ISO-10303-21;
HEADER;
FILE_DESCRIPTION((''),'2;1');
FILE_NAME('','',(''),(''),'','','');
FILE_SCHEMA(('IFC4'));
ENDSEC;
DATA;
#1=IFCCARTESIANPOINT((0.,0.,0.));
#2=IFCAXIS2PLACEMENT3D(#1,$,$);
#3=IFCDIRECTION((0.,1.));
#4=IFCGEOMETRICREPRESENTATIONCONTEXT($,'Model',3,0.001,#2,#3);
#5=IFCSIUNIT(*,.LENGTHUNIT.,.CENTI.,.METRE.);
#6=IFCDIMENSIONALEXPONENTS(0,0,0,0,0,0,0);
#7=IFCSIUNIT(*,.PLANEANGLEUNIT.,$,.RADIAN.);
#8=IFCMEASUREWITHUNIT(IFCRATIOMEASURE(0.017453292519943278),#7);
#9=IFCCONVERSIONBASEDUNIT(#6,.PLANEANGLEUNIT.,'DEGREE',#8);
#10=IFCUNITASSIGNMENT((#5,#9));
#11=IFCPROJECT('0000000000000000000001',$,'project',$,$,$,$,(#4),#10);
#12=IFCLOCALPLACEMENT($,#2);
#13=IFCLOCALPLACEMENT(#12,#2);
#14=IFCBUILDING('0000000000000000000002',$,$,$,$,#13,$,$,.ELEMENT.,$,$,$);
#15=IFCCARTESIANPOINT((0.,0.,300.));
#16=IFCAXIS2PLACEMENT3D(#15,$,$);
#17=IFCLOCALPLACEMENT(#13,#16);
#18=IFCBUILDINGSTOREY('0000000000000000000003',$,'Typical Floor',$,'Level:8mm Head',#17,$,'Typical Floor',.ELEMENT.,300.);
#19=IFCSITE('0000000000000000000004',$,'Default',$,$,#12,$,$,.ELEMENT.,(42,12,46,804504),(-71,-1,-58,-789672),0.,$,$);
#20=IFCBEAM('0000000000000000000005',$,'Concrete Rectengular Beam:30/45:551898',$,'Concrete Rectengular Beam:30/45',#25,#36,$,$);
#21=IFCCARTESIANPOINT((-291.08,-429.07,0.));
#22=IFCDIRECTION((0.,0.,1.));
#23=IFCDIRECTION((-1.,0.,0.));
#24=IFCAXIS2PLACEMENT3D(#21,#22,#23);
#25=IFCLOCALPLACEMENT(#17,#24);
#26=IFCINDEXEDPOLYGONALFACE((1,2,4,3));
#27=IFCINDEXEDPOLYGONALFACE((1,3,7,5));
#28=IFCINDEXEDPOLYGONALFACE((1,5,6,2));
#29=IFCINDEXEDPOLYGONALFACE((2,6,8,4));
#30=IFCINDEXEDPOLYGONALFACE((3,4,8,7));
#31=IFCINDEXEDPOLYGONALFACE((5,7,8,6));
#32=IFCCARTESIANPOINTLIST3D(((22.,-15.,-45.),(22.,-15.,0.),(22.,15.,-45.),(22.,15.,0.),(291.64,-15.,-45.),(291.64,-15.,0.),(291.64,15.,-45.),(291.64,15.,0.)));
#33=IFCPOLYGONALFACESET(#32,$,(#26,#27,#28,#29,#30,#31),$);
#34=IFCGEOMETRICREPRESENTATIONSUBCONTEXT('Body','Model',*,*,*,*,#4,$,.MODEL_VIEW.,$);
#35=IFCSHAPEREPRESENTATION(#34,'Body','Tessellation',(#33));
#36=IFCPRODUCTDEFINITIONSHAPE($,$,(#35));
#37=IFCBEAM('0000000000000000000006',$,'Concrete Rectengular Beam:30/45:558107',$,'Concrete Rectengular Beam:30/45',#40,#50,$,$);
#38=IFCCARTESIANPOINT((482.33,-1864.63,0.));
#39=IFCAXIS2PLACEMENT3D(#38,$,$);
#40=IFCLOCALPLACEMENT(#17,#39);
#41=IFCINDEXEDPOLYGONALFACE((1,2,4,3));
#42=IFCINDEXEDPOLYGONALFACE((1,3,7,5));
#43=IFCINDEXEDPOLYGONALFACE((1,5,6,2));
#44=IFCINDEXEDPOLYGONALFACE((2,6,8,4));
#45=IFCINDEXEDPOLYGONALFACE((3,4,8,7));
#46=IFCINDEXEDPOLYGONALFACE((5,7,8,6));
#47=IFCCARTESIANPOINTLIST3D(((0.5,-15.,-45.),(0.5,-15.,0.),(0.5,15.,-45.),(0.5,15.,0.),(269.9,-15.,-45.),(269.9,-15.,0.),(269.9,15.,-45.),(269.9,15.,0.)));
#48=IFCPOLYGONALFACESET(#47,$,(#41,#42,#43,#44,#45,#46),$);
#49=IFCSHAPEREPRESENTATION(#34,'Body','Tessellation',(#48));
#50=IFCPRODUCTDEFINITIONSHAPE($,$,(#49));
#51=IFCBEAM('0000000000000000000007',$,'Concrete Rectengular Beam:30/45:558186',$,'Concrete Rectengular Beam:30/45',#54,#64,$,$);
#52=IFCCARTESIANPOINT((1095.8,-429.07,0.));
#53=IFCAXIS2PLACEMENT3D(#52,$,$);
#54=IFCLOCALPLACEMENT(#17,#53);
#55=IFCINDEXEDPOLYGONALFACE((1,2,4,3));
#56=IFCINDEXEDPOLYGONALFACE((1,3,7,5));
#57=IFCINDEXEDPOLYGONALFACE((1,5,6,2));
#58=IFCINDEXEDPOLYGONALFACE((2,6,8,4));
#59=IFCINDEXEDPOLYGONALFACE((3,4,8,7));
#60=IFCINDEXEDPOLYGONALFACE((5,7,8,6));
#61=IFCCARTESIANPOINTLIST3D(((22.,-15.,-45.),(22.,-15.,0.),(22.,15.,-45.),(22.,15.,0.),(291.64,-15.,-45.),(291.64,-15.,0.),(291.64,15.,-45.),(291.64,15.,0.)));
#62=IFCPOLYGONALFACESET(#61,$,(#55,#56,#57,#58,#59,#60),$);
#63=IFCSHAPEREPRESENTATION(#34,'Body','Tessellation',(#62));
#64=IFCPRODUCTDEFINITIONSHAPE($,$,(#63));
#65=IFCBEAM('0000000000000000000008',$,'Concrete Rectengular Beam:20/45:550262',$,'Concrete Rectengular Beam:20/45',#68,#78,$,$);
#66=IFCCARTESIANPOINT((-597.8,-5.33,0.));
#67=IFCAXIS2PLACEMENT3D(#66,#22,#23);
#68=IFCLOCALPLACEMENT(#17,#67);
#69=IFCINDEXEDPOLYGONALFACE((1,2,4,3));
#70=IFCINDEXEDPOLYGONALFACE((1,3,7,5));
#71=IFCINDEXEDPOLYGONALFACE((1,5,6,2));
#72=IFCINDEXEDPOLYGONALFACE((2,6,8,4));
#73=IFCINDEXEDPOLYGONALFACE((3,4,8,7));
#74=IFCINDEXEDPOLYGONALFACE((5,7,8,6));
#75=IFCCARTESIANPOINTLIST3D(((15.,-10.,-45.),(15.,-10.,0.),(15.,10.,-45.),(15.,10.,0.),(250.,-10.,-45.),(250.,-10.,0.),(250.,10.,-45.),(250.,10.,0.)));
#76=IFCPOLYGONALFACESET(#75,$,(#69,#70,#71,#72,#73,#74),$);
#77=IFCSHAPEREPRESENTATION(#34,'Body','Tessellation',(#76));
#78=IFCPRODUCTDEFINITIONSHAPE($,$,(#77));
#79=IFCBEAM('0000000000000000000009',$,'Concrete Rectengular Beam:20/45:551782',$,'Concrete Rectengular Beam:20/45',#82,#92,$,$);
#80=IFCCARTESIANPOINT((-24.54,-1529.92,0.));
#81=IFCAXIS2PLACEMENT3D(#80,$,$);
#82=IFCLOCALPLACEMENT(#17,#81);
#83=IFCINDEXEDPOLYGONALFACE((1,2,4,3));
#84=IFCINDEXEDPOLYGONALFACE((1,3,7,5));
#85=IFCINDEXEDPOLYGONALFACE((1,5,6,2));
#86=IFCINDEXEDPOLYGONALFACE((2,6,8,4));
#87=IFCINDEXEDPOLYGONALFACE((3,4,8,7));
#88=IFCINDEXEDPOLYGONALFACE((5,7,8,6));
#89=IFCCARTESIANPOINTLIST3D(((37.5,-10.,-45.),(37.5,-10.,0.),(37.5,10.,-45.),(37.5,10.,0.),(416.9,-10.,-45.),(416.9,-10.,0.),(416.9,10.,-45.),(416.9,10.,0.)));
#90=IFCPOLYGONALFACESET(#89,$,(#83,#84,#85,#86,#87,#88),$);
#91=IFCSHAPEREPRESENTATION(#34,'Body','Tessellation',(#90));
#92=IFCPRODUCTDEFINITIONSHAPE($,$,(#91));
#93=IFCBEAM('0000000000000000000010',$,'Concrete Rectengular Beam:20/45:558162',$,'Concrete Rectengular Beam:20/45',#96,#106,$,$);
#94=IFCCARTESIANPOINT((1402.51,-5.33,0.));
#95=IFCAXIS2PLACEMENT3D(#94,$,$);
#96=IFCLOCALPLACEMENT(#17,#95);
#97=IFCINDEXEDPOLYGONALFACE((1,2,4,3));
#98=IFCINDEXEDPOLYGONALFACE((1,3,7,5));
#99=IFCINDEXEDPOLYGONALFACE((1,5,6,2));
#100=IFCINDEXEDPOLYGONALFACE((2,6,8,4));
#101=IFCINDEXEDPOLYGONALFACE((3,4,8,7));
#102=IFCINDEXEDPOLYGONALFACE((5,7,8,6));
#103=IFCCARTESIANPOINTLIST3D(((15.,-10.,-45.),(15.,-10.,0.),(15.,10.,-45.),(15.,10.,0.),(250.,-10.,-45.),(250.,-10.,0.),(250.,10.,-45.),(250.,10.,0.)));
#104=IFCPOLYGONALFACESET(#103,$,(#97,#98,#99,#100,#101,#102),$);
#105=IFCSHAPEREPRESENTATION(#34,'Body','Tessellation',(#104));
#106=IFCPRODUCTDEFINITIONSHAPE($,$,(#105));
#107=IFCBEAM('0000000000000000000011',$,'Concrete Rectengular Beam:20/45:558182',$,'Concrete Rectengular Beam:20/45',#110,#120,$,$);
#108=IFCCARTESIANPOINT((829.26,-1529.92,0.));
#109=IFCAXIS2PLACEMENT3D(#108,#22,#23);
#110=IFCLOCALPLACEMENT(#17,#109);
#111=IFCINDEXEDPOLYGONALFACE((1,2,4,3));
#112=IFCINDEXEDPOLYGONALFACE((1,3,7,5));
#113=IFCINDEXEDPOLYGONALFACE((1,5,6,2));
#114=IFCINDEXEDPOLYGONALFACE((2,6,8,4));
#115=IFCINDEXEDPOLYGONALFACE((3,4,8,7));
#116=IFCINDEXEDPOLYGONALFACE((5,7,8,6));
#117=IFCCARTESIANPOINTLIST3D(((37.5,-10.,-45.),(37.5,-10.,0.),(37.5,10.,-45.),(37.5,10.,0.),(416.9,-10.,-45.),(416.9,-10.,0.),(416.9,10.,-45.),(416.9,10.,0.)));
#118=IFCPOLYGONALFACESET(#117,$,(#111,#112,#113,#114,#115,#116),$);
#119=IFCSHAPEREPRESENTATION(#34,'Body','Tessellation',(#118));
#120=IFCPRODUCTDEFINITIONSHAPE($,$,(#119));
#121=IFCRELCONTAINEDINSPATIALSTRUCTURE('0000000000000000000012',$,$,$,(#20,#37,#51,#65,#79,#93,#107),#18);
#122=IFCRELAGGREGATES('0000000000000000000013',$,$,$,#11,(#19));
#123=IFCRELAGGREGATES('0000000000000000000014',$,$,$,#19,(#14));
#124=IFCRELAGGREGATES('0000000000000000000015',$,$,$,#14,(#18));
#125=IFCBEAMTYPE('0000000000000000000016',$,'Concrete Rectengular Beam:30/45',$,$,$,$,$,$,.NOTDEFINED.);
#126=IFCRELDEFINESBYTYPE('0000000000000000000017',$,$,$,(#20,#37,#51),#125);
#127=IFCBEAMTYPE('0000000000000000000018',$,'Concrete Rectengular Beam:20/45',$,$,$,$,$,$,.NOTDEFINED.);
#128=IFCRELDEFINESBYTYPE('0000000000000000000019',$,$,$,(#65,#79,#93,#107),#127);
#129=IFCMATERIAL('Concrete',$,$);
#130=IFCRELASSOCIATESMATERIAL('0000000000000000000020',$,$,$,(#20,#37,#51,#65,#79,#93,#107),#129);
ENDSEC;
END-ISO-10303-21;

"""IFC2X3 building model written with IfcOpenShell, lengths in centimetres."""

from ifc_helpers import new_model, entity, si_unit, converted_unit, direction, frame, frame_2d, origin, place, context, subcontext, project, spatial, rectangle, extrude, material, type_object, element, save


model = new_model("IFC2X3")

# Units and contexts
model_context = context("Model", 3, precision=0.001, world=origin(), true_north=direction((0.0, 1.0)))
body_context = subcontext(model_context, "Body", "Model", "MODEL_VIEW")
ifc_project = project(units=[si_unit("LENGTHUNIT", "METRE", prefix="CENTI"), converted_unit("PLANEANGLEUNIT", "DEGREE", entity("IfcRatioMeasure", 0.017453292519943278), si_unit("PLANEANGLEUNIT", "RADIAN"), dimensions=[0, 0, 0, 0, 0, 0, 0])], contexts=[model_context])

# Site, building, storey
site_placement = place(None, origin())
site = spatial("IfcSite", under=ifc_project, at=site_placement, Name="Default", CompositionType="ELEMENT", RefLatitude=(42, 12, 46, 804504), RefLongitude=(-71, -1, -58, -789672), RefElevation=0.0)
building_placement = place(site_placement, origin())
building = spatial("IfcBuilding", under=site, at=building_placement, CompositionType="ELEMENT")
storey_placement = place(building_placement, frame((0.0, 0.0, 300.0)))
storey = spatial("IfcBuildingStorey", under=building, at=storey_placement, Name="Typical Floor", ObjectType="Level:8mm Head", LongName="Typical Floor", CompositionType="ELEMENT", Elevation=300.0)

# Beams
ifc_material = material(Name="Concrete")
beam_type_1 = type_object("IfcBeamType", Name="Concrete Rectengular Beam:30/45", PredefinedType="NOTDEFINED")
beam_1_placement = place(storey_placement, frame((-291.08, -429.07, 0.0), z_axis=(0.0, 0.0, 1.0), x_axis=(-1.0, 0.0, 0.0)))
element("IfcBeam", 1, at=beam_1_placement, inside=storey, type_object=beam_type_1, material=ifc_material, Name="Concrete Rectengular Beam:30/45:551898", ObjectType="Concrete Rectengular Beam:30/45", context=body_context, shape_type="SweptSolid", body=[
    extrude(rectangle(XDim=45.0, YDim=30.0, at=frame_2d((0.0, 0.0), x_axis=(1.0, 0.0))), frame((22.0, 0.0, -22.5), z_axis=(1.0, 0.0, 0.0), x_axis=(0.0, 0.0, -1.0)), (0.0, 0.0, 1.0), 269.64),
])
beam_2_placement = place(storey_placement, frame((482.33, -1864.63, 0.0)))
element("IfcBeam", 2, at=beam_2_placement, inside=storey, type_object=beam_type_1, material=ifc_material, Name="Concrete Rectengular Beam:30/45:558107", ObjectType="Concrete Rectengular Beam:30/45", context=body_context, shape_type="SweptSolid", body=[
    extrude(rectangle(XDim=45.0, YDim=30.0, at=frame_2d((0.0, 0.0), x_axis=(1.0, 0.0))), frame((0.5, 0.0, -22.5), z_axis=(1.0, 0.0, 0.0), x_axis=(0.0, 0.0, -1.0)), (0.0, 0.0, 1.0), 269.4),
])
beam_3_placement = place(storey_placement, frame((1095.8, -429.07, 0.0)))
element("IfcBeam", 3, at=beam_3_placement, inside=storey, type_object=beam_type_1, material=ifc_material, Name="Concrete Rectengular Beam:30/45:558186", ObjectType="Concrete Rectengular Beam:30/45", context=body_context, shape_type="SweptSolid", body=[
    extrude(rectangle(XDim=45.0, YDim=30.0, at=frame_2d((0.0, 0.0), x_axis=(1.0, 0.0))), frame((22.0, 0.0, -22.5), z_axis=(1.0, 0.0, 0.0), x_axis=(0.0, 0.0, -1.0)), (0.0, 0.0, 1.0), 269.64),
])
beam_type_2 = type_object("IfcBeamType", Name="Concrete Rectengular Beam:20/45", PredefinedType="NOTDEFINED")
beam_4_placement = place(storey_placement, frame((-597.8, -5.33, 0.0), z_axis=(0.0, 0.0, 1.0), x_axis=(-1.0, 0.0, 0.0)))
element("IfcBeam", 4, at=beam_4_placement, inside=storey, type_object=beam_type_2, material=ifc_material, Name="Concrete Rectengular Beam:20/45:550262", ObjectType="Concrete Rectengular Beam:20/45", context=body_context, shape_type="SweptSolid", body=[
    extrude(rectangle(XDim=45.0, YDim=20.0, at=frame_2d((0.0, 0.0), x_axis=(1.0, 0.0))), frame((15.0, 0.0, -22.5), z_axis=(1.0, 0.0, 0.0), x_axis=(0.0, 0.0, -1.0)), (0.0, 0.0, 1.0), 235.0),
])
beam_5_placement = place(storey_placement, frame((-24.54, -1529.92, 0.0)))
element("IfcBeam", 5, at=beam_5_placement, inside=storey, type_object=beam_type_2, material=ifc_material, Name="Concrete Rectengular Beam:20/45:551782", ObjectType="Concrete Rectengular Beam:20/45", context=body_context, shape_type="SweptSolid", body=[
    extrude(rectangle(XDim=45.0, YDim=20.0, at=frame_2d((0.0, 0.0), x_axis=(1.0, 0.0))), frame((37.5, 0.0, -22.5), z_axis=(1.0, 0.0, 0.0), x_axis=(0.0, 0.0, -1.0)), (0.0, 0.0, 1.0), 379.4),
])
beam_6_placement = place(storey_placement, frame((1402.51, -5.33, 0.0)))
element("IfcBeam", 6, at=beam_6_placement, inside=storey, type_object=beam_type_2, material=ifc_material, Name="Concrete Rectengular Beam:20/45:558162", ObjectType="Concrete Rectengular Beam:20/45", context=body_context, shape_type="SweptSolid", body=[
    extrude(rectangle(XDim=45.0, YDim=20.0, at=frame_2d((0.0, 0.0), x_axis=(1.0, 0.0))), frame((15.0, 0.0, -22.5), z_axis=(1.0, 0.0, 0.0), x_axis=(0.0, 0.0, -1.0)), (0.0, 0.0, 1.0), 235.0),
])
beam_7_placement = place(storey_placement, frame((829.26, -1529.92, 0.0), z_axis=(0.0, 0.0, 1.0), x_axis=(-1.0, 0.0, 0.0)))
element("IfcBeam", 7, at=beam_7_placement, inside=storey, type_object=beam_type_2, material=ifc_material, Name="Concrete Rectengular Beam:20/45:558182", ObjectType="Concrete Rectengular Beam:20/45", context=body_context, shape_type="SweptSolid", body=[
    extrude(rectangle(XDim=45.0, YDim=20.0, at=frame_2d((0.0, 0.0), x_axis=(1.0, 0.0))), frame((37.5, 0.0, -22.5), z_axis=(1.0, 0.0, 0.0), x_axis=(0.0, 0.0, -1.0)), (0.0, 0.0, 1.0), 379.4),
])

save(model, "model.ifc")
